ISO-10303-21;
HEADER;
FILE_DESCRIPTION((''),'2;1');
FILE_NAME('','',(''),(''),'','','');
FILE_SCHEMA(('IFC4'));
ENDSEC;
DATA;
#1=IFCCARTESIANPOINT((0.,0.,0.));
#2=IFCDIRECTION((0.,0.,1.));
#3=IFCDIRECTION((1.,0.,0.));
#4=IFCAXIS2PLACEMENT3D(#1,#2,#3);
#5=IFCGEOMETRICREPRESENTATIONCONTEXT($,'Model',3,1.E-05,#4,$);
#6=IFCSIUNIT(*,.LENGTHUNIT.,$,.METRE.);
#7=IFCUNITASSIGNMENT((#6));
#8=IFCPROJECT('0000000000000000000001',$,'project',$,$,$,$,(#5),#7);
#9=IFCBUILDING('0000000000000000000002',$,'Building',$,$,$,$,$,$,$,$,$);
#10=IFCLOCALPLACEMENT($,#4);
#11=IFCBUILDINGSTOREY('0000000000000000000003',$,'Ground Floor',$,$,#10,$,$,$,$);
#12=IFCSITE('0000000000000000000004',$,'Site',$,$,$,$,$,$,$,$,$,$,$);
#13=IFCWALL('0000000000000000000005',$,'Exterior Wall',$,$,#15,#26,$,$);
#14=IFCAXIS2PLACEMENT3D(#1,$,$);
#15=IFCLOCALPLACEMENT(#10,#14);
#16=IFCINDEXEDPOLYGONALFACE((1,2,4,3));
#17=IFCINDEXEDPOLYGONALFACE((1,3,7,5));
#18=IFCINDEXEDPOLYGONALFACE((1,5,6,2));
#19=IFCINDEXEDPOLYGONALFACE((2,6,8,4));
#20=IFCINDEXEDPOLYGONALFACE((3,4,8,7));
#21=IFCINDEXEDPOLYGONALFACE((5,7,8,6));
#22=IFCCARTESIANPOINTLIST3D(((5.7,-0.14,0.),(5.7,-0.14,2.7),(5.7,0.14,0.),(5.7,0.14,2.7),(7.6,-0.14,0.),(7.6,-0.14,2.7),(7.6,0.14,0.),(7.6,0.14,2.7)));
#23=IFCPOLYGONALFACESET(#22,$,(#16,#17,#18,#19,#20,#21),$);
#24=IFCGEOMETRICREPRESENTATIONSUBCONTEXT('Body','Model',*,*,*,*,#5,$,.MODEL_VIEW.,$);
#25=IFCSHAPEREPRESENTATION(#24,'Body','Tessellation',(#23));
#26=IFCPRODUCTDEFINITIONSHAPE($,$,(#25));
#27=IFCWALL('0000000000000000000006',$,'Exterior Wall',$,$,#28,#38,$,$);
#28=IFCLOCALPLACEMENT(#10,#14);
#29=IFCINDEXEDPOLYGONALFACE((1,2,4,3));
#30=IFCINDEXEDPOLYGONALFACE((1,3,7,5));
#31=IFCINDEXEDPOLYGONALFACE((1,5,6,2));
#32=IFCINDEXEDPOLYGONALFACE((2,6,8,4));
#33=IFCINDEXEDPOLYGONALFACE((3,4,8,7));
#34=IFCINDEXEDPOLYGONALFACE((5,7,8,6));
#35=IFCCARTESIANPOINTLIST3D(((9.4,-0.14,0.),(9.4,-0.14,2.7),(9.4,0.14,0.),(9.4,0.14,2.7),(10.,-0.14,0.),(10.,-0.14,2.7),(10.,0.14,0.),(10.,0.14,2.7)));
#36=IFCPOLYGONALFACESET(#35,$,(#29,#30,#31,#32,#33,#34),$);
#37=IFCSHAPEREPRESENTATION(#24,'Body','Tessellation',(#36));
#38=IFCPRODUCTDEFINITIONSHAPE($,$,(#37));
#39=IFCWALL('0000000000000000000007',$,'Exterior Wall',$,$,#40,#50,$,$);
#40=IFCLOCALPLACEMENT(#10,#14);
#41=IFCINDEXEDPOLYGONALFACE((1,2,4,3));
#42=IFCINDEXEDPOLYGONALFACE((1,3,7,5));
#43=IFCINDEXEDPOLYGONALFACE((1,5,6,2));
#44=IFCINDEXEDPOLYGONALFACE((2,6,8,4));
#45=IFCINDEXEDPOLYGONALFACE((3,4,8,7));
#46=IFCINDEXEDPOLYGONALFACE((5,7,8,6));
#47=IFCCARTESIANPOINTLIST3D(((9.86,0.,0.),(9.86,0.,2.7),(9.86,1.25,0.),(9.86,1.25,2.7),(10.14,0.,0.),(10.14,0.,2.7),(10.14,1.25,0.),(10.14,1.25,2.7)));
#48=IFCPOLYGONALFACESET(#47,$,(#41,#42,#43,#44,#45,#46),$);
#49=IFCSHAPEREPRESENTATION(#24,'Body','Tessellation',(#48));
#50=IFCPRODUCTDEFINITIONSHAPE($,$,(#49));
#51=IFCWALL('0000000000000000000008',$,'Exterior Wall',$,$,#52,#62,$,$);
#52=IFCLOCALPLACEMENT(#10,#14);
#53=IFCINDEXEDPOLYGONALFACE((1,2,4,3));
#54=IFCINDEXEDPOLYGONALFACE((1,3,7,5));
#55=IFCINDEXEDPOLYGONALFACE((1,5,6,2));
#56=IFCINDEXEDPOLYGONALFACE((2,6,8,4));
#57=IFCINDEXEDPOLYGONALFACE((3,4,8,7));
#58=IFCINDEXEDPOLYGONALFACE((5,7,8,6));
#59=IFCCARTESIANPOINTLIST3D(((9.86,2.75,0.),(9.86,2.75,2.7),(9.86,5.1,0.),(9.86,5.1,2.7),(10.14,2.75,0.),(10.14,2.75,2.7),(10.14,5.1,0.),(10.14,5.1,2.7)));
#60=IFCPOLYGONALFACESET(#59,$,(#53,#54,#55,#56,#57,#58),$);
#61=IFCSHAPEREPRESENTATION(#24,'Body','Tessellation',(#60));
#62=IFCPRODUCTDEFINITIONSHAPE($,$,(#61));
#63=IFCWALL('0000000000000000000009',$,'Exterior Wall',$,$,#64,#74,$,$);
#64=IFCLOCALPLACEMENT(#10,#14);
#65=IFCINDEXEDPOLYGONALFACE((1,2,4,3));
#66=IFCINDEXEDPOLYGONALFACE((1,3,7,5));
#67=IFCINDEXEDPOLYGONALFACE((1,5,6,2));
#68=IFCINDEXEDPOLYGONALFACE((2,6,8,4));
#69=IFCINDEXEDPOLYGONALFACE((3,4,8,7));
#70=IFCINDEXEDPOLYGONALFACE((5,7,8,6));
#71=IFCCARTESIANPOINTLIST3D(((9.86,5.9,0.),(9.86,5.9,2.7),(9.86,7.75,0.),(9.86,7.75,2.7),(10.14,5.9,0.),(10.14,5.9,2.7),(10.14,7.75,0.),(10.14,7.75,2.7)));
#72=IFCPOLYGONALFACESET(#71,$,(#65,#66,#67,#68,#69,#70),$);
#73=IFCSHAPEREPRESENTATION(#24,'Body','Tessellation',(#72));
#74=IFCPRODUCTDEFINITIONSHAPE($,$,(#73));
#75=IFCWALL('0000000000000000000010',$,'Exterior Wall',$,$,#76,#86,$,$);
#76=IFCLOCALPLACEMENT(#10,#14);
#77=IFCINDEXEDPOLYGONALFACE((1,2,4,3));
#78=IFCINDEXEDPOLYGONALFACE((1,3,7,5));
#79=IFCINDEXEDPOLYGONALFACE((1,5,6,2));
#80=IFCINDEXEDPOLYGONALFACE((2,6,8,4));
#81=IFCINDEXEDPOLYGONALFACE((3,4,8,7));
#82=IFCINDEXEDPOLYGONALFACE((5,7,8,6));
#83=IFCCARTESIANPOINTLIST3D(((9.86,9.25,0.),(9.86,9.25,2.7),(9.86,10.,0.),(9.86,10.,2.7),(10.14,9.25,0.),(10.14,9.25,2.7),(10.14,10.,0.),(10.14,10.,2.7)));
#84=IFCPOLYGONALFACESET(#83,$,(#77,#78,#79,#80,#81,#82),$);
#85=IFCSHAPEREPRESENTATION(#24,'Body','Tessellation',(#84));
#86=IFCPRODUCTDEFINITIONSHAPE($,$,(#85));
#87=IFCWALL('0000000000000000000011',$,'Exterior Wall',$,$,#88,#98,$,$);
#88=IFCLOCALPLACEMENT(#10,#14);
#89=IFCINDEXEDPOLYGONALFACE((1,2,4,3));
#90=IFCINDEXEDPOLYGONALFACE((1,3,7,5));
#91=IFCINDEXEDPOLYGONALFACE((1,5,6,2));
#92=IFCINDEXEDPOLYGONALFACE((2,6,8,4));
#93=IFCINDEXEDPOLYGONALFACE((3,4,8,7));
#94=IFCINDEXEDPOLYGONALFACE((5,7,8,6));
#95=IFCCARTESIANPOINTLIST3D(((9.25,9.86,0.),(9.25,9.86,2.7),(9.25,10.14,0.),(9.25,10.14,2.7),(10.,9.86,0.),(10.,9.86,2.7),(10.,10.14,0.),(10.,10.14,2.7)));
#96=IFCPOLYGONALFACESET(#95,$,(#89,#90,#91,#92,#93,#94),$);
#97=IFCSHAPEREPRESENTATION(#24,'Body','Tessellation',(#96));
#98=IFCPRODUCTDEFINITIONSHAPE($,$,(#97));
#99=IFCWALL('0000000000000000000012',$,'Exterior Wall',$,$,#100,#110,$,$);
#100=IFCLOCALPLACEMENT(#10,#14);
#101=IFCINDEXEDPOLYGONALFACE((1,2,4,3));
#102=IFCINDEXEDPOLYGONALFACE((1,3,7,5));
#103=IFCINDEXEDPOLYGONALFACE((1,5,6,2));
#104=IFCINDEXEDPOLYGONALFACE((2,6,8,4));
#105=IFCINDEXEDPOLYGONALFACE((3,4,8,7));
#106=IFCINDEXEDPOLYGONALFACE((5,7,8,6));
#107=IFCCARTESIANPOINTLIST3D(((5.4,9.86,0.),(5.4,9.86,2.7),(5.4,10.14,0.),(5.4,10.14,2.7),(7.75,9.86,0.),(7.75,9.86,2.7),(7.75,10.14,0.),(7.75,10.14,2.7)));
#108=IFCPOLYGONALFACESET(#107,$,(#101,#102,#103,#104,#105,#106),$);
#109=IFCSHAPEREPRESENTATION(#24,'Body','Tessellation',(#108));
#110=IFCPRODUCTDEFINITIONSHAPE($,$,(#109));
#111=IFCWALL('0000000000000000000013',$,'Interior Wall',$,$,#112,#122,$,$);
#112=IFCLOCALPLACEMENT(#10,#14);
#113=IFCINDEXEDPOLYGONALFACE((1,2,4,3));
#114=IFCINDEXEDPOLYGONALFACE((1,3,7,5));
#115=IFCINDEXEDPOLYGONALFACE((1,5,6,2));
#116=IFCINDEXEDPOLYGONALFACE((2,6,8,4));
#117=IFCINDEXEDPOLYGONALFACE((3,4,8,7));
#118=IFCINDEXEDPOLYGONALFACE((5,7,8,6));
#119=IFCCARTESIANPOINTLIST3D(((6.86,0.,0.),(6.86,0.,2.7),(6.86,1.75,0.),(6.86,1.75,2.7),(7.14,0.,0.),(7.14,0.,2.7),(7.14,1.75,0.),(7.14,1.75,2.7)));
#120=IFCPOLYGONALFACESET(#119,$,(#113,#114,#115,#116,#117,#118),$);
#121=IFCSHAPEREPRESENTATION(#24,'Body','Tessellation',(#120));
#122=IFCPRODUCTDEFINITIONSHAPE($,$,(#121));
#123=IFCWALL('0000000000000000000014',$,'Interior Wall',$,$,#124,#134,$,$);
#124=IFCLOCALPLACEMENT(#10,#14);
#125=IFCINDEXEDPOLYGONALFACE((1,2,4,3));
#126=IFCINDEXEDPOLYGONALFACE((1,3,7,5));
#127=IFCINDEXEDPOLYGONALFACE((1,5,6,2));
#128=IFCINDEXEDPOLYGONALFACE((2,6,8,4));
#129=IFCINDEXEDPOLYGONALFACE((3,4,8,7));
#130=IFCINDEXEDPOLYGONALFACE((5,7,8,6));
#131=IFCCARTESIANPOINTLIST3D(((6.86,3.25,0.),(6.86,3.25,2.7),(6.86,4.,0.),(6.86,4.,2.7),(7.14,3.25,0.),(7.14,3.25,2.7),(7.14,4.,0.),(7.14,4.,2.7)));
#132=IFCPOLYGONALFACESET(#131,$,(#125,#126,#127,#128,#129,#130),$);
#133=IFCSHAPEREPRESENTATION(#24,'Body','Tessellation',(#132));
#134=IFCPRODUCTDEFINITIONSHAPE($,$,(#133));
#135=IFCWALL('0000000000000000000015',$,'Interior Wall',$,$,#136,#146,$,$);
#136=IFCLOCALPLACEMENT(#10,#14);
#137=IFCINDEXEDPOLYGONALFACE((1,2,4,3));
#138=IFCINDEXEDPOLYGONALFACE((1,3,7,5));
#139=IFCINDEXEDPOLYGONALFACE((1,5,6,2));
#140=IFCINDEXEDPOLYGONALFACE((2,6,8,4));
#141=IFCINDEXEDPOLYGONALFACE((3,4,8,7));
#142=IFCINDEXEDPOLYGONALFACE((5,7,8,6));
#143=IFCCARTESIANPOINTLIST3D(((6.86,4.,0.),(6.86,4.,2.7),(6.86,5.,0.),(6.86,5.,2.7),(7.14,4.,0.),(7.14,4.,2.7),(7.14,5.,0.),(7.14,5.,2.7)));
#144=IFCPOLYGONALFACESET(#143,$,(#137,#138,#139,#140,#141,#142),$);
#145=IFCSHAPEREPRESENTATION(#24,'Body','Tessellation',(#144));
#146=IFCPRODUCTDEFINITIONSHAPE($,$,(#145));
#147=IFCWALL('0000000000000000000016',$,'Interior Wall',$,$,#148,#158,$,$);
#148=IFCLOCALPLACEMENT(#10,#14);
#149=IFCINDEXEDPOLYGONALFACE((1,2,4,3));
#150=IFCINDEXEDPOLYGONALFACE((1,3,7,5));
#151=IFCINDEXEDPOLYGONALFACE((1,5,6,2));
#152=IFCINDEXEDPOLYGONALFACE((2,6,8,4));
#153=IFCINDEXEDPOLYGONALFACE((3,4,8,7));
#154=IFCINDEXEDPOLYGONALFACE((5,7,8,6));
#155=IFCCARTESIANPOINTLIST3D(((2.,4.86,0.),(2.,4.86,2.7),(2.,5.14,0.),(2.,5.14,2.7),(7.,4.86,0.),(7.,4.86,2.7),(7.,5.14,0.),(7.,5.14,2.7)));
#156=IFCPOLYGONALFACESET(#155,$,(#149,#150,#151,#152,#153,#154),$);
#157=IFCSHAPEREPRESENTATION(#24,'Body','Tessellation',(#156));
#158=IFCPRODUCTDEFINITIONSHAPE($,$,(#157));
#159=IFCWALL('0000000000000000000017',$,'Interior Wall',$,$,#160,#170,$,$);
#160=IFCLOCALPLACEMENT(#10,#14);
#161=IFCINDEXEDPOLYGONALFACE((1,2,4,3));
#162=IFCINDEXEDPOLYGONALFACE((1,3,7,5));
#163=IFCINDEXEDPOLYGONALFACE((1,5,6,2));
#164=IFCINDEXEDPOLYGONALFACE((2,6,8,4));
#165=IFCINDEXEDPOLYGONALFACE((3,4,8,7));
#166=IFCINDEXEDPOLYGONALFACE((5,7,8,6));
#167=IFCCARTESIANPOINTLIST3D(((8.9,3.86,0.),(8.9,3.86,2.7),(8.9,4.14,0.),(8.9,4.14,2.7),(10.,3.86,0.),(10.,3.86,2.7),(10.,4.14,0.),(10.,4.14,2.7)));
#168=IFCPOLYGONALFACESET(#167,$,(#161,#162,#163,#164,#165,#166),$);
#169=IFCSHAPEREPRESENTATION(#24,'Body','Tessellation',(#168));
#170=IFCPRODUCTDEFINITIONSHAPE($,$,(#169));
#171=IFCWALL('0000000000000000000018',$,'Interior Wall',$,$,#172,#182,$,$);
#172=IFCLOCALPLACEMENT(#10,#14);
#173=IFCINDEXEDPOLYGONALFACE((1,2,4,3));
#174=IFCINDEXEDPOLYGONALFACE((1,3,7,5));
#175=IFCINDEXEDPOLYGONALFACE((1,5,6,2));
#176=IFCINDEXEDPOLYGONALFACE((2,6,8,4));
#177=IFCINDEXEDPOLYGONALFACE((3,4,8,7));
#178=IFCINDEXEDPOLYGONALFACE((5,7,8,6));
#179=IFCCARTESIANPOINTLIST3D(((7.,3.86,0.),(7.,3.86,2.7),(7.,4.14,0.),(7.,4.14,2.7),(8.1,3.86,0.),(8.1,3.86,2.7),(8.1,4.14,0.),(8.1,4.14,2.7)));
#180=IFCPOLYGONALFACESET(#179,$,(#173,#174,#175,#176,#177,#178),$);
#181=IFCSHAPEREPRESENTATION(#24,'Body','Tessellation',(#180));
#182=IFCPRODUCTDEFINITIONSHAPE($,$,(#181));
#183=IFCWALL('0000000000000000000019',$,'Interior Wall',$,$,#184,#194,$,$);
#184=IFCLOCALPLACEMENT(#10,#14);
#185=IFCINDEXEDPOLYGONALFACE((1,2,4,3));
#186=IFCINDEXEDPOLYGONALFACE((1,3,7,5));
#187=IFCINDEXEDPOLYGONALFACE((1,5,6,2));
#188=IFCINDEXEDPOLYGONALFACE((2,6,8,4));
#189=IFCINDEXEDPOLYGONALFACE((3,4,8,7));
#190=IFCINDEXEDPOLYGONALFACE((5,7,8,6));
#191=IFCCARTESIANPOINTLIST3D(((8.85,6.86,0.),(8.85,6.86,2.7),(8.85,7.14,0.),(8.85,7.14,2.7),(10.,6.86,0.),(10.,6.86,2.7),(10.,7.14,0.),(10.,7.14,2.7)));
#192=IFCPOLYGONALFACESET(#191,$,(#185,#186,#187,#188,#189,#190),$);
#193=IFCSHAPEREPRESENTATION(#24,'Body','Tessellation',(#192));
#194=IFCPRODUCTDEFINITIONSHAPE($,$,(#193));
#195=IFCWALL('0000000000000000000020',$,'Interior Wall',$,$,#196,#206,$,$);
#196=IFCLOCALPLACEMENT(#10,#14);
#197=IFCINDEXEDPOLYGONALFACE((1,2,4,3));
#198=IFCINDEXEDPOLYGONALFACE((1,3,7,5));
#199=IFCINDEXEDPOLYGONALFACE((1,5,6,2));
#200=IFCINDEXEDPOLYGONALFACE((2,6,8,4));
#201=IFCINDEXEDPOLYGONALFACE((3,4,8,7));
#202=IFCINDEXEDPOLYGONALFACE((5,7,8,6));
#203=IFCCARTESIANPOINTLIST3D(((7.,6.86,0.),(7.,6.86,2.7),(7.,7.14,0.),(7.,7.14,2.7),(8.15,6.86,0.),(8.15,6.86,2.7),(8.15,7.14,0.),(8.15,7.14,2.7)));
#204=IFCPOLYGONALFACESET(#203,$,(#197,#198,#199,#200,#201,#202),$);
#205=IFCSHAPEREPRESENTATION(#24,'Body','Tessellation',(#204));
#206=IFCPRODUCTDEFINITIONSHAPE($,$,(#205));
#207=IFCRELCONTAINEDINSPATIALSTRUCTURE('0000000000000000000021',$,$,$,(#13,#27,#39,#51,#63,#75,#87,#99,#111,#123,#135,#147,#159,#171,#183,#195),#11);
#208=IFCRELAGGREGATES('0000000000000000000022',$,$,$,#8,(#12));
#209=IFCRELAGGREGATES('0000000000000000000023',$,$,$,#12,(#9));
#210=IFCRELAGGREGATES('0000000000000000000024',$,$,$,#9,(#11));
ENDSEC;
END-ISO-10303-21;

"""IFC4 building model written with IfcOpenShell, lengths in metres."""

from ifc_helpers import new_model, si_unit, frame, origin_with_axes, place, context, subcontext, project, spatial, indexed_curve, outline, extrude, element, save


model = new_model("IFC4")

# Units and contexts
model_context = context("Model", 3, precision=1e-05, world=origin_with_axes())
body_context = subcontext(model_context, "Body", "Model", "MODEL_VIEW")
ifc_project = project(units=[si_unit("LENGTHUNIT", "METRE")], contexts=[model_context])

# Site, building, storey
site = spatial("IfcSite", under=ifc_project, Name="Site")
building = spatial("IfcBuilding", under=site, Name="Building")
storey_placement = place(None, origin_with_axes())
storey = spatial("IfcBuildingStorey", under=building, at=storey_placement, Name="Ground Floor")

# Walls
wall_1_placement = place(storey_placement, frame((5.7, 0.0, 0.0), z_axis=(0.0, 0.0, 1.0), x_axis=(1.0, 0.0, 0.0)))
element("IfcWall", 1, at=wall_1_placement, inside=storey, Name="Exterior Wall", context=body_context, shape_type="SweptSolid", body=[
    extrude(outline(indexed_curve([(0.0, 0.0), (0.0, 0.28), (1.9, 0.28), (1.9, 0.0), (0.0, 0.0)], self_intersect=False)), frame((0.0, -0.14, 0.0), z_axis=(0.0, 0.0, 1.0), x_axis=(1.0, 0.0, 0.0)), (0.0, 0.0, 1.0), 2.7),
])
wall_2_placement = place(storey_placement, frame((9.4, 0.0, 0.0), z_axis=(0.0, 0.0, 1.0), x_axis=(1.0, 0.0, 0.0)))
element("IfcWall", 2, at=wall_2_placement, inside=storey, Name="Exterior Wall", context=body_context, shape_type="SweptSolid", body=[
    extrude(outline(indexed_curve([(0.0, 0.0), (0.0, 0.28), (0.6, 0.28), (0.6, 0.0), (0.0, 0.0)], self_intersect=False)), frame((0.0, -0.14, 0.0), z_axis=(0.0, 0.0, 1.0), x_axis=(1.0, 0.0, 0.0)), (0.0, 0.0, 1.0), 2.7),
])
wall_3_placement = place(storey_placement, frame((10.0, 0.0, 0.0), z_axis=(0.0, 0.0, 1.0), x_axis=(0.0, 1.0, 0.0)))
element("IfcWall", 3, at=wall_3_placement, inside=storey, Name="Exterior Wall", context=body_context, shape_type="SweptSolid", body=[
    extrude(outline(indexed_curve([(0.0, 0.0), (0.0, 0.28), (1.25, 0.28), (1.25, 0.0), (0.0, 0.0)], self_intersect=False)), frame((0.0, -0.14, 0.0), z_axis=(0.0, 0.0, 1.0), x_axis=(1.0, 0.0, 0.0)), (0.0, 0.0, 1.0), 2.7),
])
wall_4_placement = place(storey_placement, frame((10.0, 2.75, 0.0), z_axis=(0.0, 0.0, 1.0), x_axis=(0.0, 1.0, 0.0)))
element("IfcWall", 4, at=wall_4_placement, inside=storey, Name="Exterior Wall", context=body_context, shape_type="SweptSolid", body=[
    extrude(outline(indexed_curve([(0.0, 0.0), (0.0, 0.28), (2.35, 0.28), (2.35, 0.0), (0.0, 0.0)], self_intersect=False)), frame((0.0, -0.14, 0.0), z_axis=(0.0, 0.0, 1.0), x_axis=(1.0, 0.0, 0.0)), (0.0, 0.0, 1.0), 2.7),
])
wall_5_placement = place(storey_placement, frame((10.0, 5.9, 0.0), z_axis=(0.0, 0.0, 1.0), x_axis=(0.0, 1.0, 0.0)))
element("IfcWall", 5, at=wall_5_placement, inside=storey, Name="Exterior Wall", context=body_context, shape_type="SweptSolid", body=[
    extrude(outline(indexed_curve([(0.0, 0.0), (0.0, 0.28), (1.85, 0.28), (1.85, 0.0), (0.0, 0.0)], self_intersect=False)), frame((0.0, -0.14, 0.0), z_axis=(0.0, 0.0, 1.0), x_axis=(1.0, 0.0, 0.0)), (0.0, 0.0, 1.0), 2.7),
])
for number, where, z_axis, x_axis, name in (
    (6, (10.0, 9.25, 0.0), (0.0, 0.0, 1.0), (0.0, 1.0, 0.0), "Exterior Wall"),
    (7, (10.0, 10.0, 0.0), (0.0, 0.0, 1.0), (-1.0, 0.0, 0.0), "Exterior Wall"),
):
    element("IfcWall", number, at=place(storey_placement, frame(where, z_axis=z_axis, x_axis=x_axis)), inside=storey, Name=name, context=body_context, shape_type="SweptSolid", body=[
        extrude(outline(indexed_curve([(0.0, 0.0), (0.0, 0.28), (0.75, 0.28), (0.75, 0.0), (0.0, 0.0)], self_intersect=False)), frame((0.0, -0.14, 0.0), z_axis=(0.0, 0.0, 1.0), x_axis=(1.0, 0.0, 0.0)), (0.0, 0.0, 1.0), 2.7),
    ])
wall_6_placement = place(storey_placement, frame((7.75, 10.0, 0.0), z_axis=(0.0, 0.0, 1.0), x_axis=(-1.0, 0.0, 0.0)))
element("IfcWall", 8, at=wall_6_placement, inside=storey, Name="Exterior Wall", context=body_context, shape_type="SweptSolid", body=[
    extrude(outline(indexed_curve([(0.0, 0.0), (0.0, 0.28), (2.35, 0.28), (2.35, 0.0), (0.0, 0.0)], self_intersect=False)), frame((0.0, -0.14, 0.0), z_axis=(0.0, 0.0, 1.0), x_axis=(1.0, 0.0, 0.0)), (0.0, 0.0, 1.0), 2.7),
])
wall_7_placement = place(storey_placement, frame((7.0, 0.0, 0.0), z_axis=(0.0, 0.0, 1.0), x_axis=(0.0, 1.0, 0.0)))
element("IfcWall", 9, at=wall_7_placement, inside=storey, Name="Interior Wall", context=body_context, shape_type="SweptSolid", body=[
    extrude(outline(indexed_curve([(0.0, 0.0), (0.0, 0.28), (1.75, 0.28), (1.75, 0.0), (0.0, 0.0)], self_intersect=False)), frame((0.0, -0.14, 0.0), z_axis=(0.0, 0.0, 1.0), x_axis=(1.0, 0.0, 0.0)), (0.0, 0.0, 1.0), 2.7),
])
wall_8_placement = place(storey_placement, frame((7.0, 3.25, 0.0), z_axis=(0.0, 0.0, 1.0), x_axis=(0.0, 1.0, 0.0)))
element("IfcWall", 10, at=wall_8_placement, inside=storey, Name="Interior Wall", context=body_context, shape_type="SweptSolid", body=[
    extrude(outline(indexed_curve([(0.0, 0.0), (0.0, 0.28), (0.75, 0.28), (0.75, 0.0), (0.0, 0.0)], self_intersect=False)), frame((0.0, -0.14, 0.0), z_axis=(0.0, 0.0, 1.0), x_axis=(1.0, 0.0, 0.0)), (0.0, 0.0, 1.0), 2.7),
])
wall_9_placement = place(storey_placement, frame((7.0, 4.0, 0.0), z_axis=(0.0, 0.0, 1.0), x_axis=(0.0, 1.0, 0.0)))
element("IfcWall", 11, at=wall_9_placement, inside=storey, Name="Interior Wall", context=body_context, shape_type="SweptSolid", body=[
    extrude(outline(indexed_curve([(0.0, 0.0), (0.0, 0.28), (1.0, 0.28), (1.0, 0.0), (0.0, 0.0)], self_intersect=False)), frame((0.0, -0.14, 0.0), z_axis=(0.0, 0.0, 1.0), x_axis=(1.0, 0.0, 0.0)), (0.0, 0.0, 1.0), 2.7),
])
wall_10_placement = place(storey_placement, frame((7.0, 5.0, 0.0), z_axis=(0.0, 0.0, 1.0), x_axis=(-1.0, 0.0, 0.0)))
element("IfcWall", 12, at=wall_10_placement, inside=storey, Name="Interior Wall", context=body_context, shape_type="SweptSolid", body=[
    extrude(outline(indexed_curve([(0.0, 0.0), (0.0, 0.28), (5.0, 0.28), (5.0, 0.0), (0.0, 0.0)], self_intersect=False)), frame((0.0, -0.14, 0.0), z_axis=(0.0, 0.0, 1.0), x_axis=(1.0, 0.0, 0.0)), (0.0, 0.0, 1.0), 2.7),
])
for number, where, z_axis, x_axis, name in (
    (13, (10.0, 4.0, 0.0), (0.0, 0.0, 1.0), (-1.0, 0.0, 0.0), "Interior Wall"),
    (14, (8.1, 4.0, 0.0), (0.0, 0.0, 1.0), (-1.0, 0.0, 0.0), "Interior Wall"),
):
    element("IfcWall", number, at=place(storey_placement, frame(where, z_axis=z_axis, x_axis=x_axis)), inside=storey, Name=name, context=body_context, shape_type="SweptSolid", body=[
        extrude(outline(indexed_curve([(0.0, 0.0), (0.0, 0.28), (1.1, 0.28), (1.1, 0.0), (0.0, 0.0)], self_intersect=False)), frame((0.0, -0.14, 0.0), z_axis=(0.0, 0.0, 1.0), x_axis=(1.0, 0.0, 0.0)), (0.0, 0.0, 1.0), 2.7),
    ])
for number, where, z_axis, x_axis, name in (
    (15, (10.0, 7.0, 0.0), (0.0, 0.0, 1.0), (-1.0, 0.0, 0.0), "Interior Wall"),
    (16, (8.15, 7.0, 0.0), (0.0, 0.0, 1.0), (-1.0, 0.0, 0.0), "Interior Wall"),
):
    element("IfcWall", number, at=place(storey_placement, frame(where, z_axis=z_axis, x_axis=x_axis)), inside=storey, Name=name, context=body_context, shape_type="SweptSolid", body=[
        extrude(outline(indexed_curve([(0.0, 0.0), (0.0, 0.28), (1.15, 0.28), (1.15, 0.0), (0.0, 0.0)], self_intersect=False)), frame((0.0, -0.14, 0.0), z_axis=(0.0, 0.0, 1.0), x_axis=(1.0, 0.0, 0.0)), (0.0, 0.0, 1.0), 2.7),
    ])

save(model, "model.ifc")
